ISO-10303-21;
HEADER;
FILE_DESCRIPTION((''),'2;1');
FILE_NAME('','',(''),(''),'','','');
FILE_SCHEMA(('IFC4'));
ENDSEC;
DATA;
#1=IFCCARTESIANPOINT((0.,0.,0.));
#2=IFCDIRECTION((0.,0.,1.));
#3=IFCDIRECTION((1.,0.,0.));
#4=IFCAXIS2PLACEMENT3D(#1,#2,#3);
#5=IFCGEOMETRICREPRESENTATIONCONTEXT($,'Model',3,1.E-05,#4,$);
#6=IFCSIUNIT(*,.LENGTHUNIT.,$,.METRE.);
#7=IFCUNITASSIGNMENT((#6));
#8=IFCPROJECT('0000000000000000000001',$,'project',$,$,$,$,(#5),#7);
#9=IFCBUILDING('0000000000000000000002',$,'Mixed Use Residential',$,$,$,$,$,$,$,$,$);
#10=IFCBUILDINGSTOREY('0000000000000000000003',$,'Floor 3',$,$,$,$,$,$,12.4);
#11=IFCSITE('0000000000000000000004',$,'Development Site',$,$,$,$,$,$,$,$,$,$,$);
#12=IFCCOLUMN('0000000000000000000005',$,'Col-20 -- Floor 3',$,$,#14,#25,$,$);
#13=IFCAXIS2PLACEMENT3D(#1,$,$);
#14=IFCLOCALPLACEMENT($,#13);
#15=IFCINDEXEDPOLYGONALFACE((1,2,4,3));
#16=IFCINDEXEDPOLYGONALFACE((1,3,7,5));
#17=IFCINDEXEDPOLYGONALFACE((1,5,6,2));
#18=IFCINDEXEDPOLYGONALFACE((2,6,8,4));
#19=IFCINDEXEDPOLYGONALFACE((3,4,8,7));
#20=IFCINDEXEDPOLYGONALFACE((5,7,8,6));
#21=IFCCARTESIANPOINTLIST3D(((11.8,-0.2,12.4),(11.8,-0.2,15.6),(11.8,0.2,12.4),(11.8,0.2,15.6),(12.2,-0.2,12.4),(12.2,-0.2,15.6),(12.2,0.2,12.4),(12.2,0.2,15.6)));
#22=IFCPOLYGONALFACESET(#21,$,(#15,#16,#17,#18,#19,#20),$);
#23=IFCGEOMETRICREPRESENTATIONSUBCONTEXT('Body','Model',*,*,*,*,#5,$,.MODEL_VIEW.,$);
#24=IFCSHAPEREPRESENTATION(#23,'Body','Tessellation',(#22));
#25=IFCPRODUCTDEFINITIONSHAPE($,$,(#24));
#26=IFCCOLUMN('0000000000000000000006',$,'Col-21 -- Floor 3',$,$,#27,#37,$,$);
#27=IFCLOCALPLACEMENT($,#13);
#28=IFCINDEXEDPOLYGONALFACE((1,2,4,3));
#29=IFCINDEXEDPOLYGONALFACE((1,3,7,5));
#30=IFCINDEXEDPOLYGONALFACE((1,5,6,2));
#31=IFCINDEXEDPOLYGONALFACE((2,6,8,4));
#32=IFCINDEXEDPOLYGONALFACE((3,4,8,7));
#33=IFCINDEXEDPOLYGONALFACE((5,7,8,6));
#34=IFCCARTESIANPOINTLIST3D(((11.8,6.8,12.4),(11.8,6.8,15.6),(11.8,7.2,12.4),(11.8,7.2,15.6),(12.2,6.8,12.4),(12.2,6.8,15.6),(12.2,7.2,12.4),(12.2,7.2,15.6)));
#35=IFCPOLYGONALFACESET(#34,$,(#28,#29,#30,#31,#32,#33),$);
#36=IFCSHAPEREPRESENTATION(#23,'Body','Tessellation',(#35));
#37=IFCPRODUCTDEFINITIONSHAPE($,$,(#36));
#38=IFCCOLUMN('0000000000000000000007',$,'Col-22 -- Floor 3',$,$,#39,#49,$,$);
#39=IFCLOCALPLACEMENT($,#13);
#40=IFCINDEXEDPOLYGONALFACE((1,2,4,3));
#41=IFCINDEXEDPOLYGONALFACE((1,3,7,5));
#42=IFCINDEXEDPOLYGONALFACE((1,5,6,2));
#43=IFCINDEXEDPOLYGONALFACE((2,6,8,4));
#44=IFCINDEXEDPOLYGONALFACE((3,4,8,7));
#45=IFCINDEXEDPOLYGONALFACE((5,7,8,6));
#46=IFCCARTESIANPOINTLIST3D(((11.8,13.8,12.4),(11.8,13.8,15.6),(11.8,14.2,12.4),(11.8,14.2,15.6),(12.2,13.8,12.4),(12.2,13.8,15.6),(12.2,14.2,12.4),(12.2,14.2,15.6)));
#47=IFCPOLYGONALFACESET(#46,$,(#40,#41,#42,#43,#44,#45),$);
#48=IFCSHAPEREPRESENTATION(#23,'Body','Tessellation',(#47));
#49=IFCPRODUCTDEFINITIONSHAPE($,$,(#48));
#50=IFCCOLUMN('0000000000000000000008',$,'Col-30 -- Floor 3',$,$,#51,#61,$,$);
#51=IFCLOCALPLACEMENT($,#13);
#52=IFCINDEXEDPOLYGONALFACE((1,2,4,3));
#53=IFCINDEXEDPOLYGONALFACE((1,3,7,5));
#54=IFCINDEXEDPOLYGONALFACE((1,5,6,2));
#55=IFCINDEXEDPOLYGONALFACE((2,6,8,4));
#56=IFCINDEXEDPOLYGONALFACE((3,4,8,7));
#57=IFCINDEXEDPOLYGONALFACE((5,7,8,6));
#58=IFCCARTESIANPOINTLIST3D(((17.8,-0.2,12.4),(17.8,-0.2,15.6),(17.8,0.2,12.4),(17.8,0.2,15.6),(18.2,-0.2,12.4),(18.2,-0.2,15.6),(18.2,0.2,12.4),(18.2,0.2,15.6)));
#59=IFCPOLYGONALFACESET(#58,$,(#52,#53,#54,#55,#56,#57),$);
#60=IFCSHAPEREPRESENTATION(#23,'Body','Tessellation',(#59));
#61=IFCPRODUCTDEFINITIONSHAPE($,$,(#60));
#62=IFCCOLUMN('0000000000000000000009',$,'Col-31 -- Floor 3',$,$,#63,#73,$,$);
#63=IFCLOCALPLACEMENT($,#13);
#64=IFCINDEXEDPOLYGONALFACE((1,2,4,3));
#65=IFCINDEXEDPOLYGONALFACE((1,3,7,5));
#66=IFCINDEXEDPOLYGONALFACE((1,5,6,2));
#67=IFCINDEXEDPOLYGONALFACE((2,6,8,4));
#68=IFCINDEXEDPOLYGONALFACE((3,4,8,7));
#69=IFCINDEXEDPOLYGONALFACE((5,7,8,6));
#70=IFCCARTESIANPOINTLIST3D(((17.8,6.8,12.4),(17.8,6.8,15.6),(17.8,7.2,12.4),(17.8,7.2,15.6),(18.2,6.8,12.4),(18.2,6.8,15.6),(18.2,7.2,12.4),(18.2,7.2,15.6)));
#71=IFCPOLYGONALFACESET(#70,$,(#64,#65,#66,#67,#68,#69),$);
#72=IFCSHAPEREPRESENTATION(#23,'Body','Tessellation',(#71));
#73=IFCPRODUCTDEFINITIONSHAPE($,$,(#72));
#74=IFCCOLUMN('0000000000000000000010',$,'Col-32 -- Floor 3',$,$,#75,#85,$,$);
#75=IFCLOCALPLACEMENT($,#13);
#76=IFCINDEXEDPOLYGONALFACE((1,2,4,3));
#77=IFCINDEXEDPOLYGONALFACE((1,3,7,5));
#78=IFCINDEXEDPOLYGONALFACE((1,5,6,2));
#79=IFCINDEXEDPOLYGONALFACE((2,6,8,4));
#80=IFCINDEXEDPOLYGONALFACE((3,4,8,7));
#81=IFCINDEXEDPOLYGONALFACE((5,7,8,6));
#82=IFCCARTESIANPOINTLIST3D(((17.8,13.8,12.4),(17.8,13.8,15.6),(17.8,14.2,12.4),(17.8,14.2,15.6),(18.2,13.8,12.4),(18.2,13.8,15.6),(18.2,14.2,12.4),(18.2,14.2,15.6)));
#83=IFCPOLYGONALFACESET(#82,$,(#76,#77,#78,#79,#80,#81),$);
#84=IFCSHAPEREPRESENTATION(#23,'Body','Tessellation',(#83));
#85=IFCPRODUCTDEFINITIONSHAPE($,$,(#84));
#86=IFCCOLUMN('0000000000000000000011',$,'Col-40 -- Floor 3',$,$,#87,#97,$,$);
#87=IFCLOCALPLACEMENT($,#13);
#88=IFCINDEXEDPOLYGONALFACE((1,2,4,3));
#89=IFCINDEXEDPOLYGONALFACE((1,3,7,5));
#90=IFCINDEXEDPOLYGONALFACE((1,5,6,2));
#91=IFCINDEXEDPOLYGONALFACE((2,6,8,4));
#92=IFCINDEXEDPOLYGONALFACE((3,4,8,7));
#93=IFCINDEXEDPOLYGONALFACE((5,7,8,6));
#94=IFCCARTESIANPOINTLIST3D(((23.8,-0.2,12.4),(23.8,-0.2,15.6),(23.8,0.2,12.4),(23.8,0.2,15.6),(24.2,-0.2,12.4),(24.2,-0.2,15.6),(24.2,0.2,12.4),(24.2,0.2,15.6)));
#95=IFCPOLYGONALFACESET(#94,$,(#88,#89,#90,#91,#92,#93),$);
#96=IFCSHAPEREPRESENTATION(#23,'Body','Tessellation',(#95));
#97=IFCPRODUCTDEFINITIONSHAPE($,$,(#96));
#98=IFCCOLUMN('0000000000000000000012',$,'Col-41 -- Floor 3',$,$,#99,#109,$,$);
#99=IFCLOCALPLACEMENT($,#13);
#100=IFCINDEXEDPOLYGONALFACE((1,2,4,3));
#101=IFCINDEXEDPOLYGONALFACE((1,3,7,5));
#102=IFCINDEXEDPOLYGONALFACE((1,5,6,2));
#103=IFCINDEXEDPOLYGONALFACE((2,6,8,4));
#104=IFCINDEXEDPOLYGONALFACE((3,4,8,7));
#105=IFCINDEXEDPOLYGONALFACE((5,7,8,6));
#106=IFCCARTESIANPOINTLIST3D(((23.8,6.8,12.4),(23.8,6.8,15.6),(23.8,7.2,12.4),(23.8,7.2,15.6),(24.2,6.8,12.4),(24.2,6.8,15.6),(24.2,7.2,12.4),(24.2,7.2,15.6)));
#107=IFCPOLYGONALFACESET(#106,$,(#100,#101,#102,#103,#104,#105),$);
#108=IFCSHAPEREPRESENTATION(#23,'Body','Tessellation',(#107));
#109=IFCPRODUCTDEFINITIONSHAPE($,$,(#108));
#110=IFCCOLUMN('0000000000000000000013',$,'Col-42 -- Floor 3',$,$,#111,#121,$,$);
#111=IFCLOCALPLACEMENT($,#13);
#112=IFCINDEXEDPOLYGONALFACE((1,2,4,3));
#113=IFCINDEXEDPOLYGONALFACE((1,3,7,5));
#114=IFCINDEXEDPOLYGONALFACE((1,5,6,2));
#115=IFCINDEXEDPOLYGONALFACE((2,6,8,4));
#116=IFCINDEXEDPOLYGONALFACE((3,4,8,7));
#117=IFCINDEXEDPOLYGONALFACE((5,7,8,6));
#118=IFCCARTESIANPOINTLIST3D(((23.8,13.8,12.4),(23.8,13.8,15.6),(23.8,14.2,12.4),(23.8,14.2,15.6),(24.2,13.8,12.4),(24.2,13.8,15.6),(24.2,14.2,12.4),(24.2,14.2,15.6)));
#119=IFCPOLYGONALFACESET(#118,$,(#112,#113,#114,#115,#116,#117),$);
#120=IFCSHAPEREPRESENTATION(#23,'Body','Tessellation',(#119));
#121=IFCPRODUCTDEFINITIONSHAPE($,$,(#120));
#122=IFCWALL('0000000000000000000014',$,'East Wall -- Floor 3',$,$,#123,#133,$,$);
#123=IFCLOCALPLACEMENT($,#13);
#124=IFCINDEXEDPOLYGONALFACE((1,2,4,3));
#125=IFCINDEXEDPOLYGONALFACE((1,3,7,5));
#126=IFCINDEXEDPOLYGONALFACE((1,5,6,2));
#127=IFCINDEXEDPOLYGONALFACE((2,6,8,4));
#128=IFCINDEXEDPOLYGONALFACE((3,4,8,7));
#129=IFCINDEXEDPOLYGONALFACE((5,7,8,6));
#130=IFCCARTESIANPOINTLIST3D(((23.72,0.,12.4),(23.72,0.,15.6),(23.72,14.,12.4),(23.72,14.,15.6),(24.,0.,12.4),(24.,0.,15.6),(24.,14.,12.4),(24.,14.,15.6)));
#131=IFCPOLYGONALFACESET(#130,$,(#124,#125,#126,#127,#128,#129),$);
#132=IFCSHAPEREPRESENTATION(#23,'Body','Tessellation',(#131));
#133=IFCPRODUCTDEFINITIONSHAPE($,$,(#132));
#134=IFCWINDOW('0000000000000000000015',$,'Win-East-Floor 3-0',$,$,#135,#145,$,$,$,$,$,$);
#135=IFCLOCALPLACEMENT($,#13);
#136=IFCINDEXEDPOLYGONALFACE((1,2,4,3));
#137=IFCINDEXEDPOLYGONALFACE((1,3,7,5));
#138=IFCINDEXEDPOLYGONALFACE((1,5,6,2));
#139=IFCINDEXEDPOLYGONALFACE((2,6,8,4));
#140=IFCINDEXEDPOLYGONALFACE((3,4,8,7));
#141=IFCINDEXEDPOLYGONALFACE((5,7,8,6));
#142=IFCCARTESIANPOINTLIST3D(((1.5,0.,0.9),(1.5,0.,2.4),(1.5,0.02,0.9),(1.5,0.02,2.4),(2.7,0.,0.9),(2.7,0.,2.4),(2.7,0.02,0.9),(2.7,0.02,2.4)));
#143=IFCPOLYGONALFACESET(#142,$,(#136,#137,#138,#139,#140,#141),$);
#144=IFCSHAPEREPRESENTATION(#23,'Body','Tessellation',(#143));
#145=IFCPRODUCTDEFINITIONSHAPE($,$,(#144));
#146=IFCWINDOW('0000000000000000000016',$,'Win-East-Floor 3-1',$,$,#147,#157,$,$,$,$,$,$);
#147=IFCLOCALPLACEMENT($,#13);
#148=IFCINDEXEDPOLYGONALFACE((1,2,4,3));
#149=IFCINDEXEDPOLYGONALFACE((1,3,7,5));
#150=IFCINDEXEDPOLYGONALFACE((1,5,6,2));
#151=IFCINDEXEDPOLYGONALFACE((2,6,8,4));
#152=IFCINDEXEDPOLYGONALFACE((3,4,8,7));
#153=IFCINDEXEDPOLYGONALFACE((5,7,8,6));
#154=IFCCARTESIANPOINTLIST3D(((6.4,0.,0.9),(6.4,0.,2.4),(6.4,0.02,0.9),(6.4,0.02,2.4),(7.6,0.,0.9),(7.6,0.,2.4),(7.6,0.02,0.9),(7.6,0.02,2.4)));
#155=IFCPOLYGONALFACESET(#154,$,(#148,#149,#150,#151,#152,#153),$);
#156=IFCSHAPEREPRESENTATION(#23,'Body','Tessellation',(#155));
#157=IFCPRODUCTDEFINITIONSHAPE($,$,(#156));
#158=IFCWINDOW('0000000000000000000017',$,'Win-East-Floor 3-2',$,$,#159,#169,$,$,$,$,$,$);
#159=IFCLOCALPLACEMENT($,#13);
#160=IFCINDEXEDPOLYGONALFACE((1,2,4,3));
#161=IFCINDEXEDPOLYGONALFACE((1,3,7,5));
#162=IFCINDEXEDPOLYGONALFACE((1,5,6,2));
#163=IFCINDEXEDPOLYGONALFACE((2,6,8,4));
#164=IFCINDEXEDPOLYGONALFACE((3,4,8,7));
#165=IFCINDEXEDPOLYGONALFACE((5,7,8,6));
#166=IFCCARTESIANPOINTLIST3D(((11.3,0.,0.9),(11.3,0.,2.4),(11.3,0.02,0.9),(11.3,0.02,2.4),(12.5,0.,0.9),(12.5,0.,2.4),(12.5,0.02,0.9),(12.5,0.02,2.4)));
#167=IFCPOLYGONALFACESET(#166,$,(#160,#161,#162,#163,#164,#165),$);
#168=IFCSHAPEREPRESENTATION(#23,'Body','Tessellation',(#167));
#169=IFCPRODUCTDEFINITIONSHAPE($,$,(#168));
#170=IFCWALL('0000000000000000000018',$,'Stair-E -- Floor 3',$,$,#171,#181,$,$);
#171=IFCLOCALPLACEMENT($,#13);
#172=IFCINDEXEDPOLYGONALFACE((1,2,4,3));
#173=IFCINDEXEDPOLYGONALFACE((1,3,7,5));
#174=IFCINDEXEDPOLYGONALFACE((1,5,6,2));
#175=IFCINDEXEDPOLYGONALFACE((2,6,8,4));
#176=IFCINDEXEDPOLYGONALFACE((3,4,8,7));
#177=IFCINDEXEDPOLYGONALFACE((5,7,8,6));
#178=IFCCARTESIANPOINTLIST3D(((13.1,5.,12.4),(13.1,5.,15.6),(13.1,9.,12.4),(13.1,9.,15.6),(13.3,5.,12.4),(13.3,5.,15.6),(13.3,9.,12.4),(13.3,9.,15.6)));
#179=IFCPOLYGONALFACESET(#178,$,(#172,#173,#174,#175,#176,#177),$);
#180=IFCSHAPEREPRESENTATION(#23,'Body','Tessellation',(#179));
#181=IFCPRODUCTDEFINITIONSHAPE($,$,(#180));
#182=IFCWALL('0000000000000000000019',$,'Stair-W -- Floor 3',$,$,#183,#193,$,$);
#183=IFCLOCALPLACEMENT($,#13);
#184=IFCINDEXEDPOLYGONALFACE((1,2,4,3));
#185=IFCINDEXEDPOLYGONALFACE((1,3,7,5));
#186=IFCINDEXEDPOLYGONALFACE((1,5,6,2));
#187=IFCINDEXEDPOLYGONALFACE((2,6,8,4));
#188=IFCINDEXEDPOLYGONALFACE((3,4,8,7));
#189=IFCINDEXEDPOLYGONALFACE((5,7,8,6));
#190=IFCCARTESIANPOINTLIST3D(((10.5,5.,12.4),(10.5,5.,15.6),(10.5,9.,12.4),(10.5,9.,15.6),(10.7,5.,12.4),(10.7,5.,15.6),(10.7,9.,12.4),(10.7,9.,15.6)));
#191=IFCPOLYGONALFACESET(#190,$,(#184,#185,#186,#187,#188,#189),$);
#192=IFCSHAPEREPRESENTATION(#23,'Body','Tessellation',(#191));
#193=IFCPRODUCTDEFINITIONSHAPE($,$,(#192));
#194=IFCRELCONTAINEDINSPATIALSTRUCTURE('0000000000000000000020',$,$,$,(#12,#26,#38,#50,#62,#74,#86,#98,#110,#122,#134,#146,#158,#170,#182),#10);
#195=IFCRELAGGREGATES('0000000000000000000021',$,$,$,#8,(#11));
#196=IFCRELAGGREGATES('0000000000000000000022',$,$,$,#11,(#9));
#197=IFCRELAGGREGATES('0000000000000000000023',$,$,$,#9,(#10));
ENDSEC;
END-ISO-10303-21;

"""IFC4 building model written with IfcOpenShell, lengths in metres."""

from ifc_helpers import new_model, si_unit, frame, origin_with_axes, place, context, subcontext, project, spatial, indexed_curve, rectangle, outline, extrude, element, fill, save


model = new_model("IFC4")

# Units and contexts
model_context = context("Model", 3, precision=1e-05, world=origin_with_axes())
body_context = subcontext(model_context, "Body", "Model", "MODEL_VIEW")
ifc_project = project(units=[si_unit("LENGTHUNIT", "METRE")], contexts=[model_context])

# Site, building, storey
site = spatial("IfcSite", under=ifc_project, Name="Development Site")
building = spatial("IfcBuilding", under=site, Name="Mixed Use Residential")
storey = spatial("IfcBuildingStorey", under=building, Name="Floor 3", Elevation=12.4)

# Columns
for number, where, z_axis, x_axis, name in (
    (1, (12.0, 0.0, 12.4), (0.0, 0.0, 1.0), (1.0, 0.0, 0.0), "Col-20 -- Floor 3"),
    (2, (12.0, 7.0, 12.4), (0.0, 0.0, 1.0), (1.0, 0.0, 0.0), "Col-21 -- Floor 3"),
    (3, (12.0, 14.0, 12.4), (0.0, 0.0, 1.0), (1.0, 0.0, 0.0), "Col-22 -- Floor 3"),
    (4, (18.0, 0.0, 12.4), (0.0, 0.0, 1.0), (1.0, 0.0, 0.0), "Col-30 -- Floor 3"),
    (5, (18.0, 7.0, 12.4), (0.0, 0.0, 1.0), (1.0, 0.0, 0.0), "Col-31 -- Floor 3"),
    (6, (18.0, 14.0, 12.4), (0.0, 0.0, 1.0), (1.0, 0.0, 0.0), "Col-32 -- Floor 3"),
    (7, (24.0, 0.0, 12.4), (0.0, 0.0, 1.0), (1.0, 0.0, 0.0), "Col-40 -- Floor 3"),
    (8, (24.0, 7.0, 12.4), (0.0, 0.0, 1.0), (1.0, 0.0, 0.0), "Col-41 -- Floor 3"),
    (9, (24.0, 14.0, 12.4), (0.0, 0.0, 1.0), (1.0, 0.0, 0.0), "Col-42 -- Floor 3"),
):
    element("IfcColumn", number, at=place(None, frame(where, z_axis=z_axis, x_axis=x_axis)), inside=storey, Name=name, context=body_context, shape_type="SweptSolid", body=[
        extrude(rectangle(XDim=0.4, YDim=0.4), origin_with_axes(), (0.0, 0.0, 1.0), 3.2),
    ])

# Wall, openings, windows
wall_placement = place(None, frame((24.0, 0.0, 12.4), z_axis=(0.0, 0.0, 1.0), x_axis=(0.0, 1.0, 0.0)))
wall = element("IfcWall", 10, at=wall_placement, inside=storey, Name="East Wall -- Floor 3", context=body_context, shape_type="SweptSolid", body=[
    extrude(outline(indexed_curve([(0.0, 0.0), (0.0, 0.28), (14.0, 0.28), (14.0, 0.0), (0.0, 0.0)], self_intersect=False)), origin_with_axes(), (0.0, 0.0, 1.0), 3.2),
])
opening_1_placement = place(wall_placement, frame((0.0, 22.5, -11.5), z_axis=(0.0, 0.0, 1.0), x_axis=(0.0, -1.0, 0.0)))
opening_1 = element("IfcOpeningElement", 11, at=opening_1_placement, cuts=wall, context=body_context, shape_type="SweptSolid", body=[
    extrude(outline(indexed_curve([(0.0, 0.0), (0.0, 0.28), (1.2, 0.28), (1.2, 0.0), (0.0, 0.0)], self_intersect=False)), origin_with_axes(), (0.0, 0.0, 1.0), 1.5),
])
opening_2_placement = place(wall_placement, frame((0.0, 17.6, -11.5), z_axis=(0.0, 0.0, 1.0), x_axis=(0.0, -1.0, 0.0)))
opening_2 = element("IfcOpeningElement", 12, at=opening_2_placement, cuts=wall, context=body_context, shape_type="SweptSolid", body=[
    extrude(outline(indexed_curve([(0.0, 0.0), (0.0, 0.28), (1.2, 0.28), (1.2, 0.0), (0.0, 0.0)], self_intersect=False)), origin_with_axes(), (0.0, 0.0, 1.0), 1.5),
])
opening_3_placement = place(wall_placement, frame((0.0, 12.7, -11.5), z_axis=(0.0, 0.0, 1.0), x_axis=(0.0, -1.0, 0.0)))
opening_3 = element("IfcOpeningElement", 13, at=opening_3_placement, cuts=wall, context=body_context, shape_type="SweptSolid", body=[
    extrude(outline(indexed_curve([(0.0, 0.0), (0.0, 0.28), (1.2, 0.28), (1.2, 0.0), (0.0, 0.0)], self_intersect=False)), origin_with_axes(), (0.0, 0.0, 1.0), 1.5),
])
window_1_placement = place(None, frame((1.5, 0.0, 0.9), z_axis=(0.0, 0.0, 1.0), x_axis=(1.0, 0.0, 0.0)))
window_1 = element("IfcWindow", 14, at=window_1_placement, inside=storey, Name="Win-East-Floor 3-0", context=body_context, shape_type="SweptSolid", body=[
    extrude(outline(indexed_curve([(0.0, 0.0), (0.0, 0.02), (1.2, 0.02), (1.2, 0.0), (0.0, 0.0)], self_intersect=False)), origin_with_axes(), (0.0, 0.0, 1.0), 1.5),
])
fill(opening_1, window_1)
window_2_placement = place(None, frame((6.4, 0.0, 0.9), z_axis=(0.0, 0.0, 1.0), x_axis=(1.0, 0.0, 0.0)))
window_2 = element("IfcWindow", 15, at=window_2_placement, inside=storey, Name="Win-East-Floor 3-1", context=body_context, shape_type="SweptSolid", body=[
    extrude(outline(indexed_curve([(0.0, 0.0), (0.0, 0.02), (1.2, 0.02), (1.2, 0.0), (0.0, 0.0)], self_intersect=False)), origin_with_axes(), (0.0, 0.0, 1.0), 1.5),
])
fill(opening_2, window_2)
window_3_placement = place(None, frame((11.3, 0.0, 0.9), z_axis=(0.0, 0.0, 1.0), x_axis=(1.0, 0.0, 0.0)))
window_3 = element("IfcWindow", 16, at=window_3_placement, inside=storey, Name="Win-East-Floor 3-2", context=body_context, shape_type="SweptSolid", body=[
    extrude(outline(indexed_curve([(0.0, 0.0), (0.0, 0.02), (1.2, 0.02), (1.2, 0.0), (0.0, 0.0)], self_intersect=False)), origin_with_axes(), (0.0, 0.0, 1.0), 1.5),
])
fill(opening_3, window_3)

# Walls
for number, where, z_axis, x_axis, name in (
    (17, (13.3, 5.0, 12.4), (0.0, 0.0, 1.0), (0.0, 1.0, 0.0), "Stair-E -- Floor 3"),
    (18, (10.7, 5.0, 12.4), (0.0, 0.0, 1.0), (0.0, 1.0, 0.0), "Stair-W -- Floor 3"),
):
    element("IfcWall", number, at=place(None, frame(where, z_axis=z_axis, x_axis=x_axis)), inside=storey, Name=name, context=body_context, shape_type="SweptSolid", body=[
        extrude(outline(indexed_curve([(0.0, 0.0), (0.0, 0.2), (4.0, 0.2), (4.0, 0.0), (0.0, 0.0)], self_intersect=False)), origin_with_axes(), (0.0, 0.0, 1.0), 3.2),
    ])

save(model, "model.ifc")
